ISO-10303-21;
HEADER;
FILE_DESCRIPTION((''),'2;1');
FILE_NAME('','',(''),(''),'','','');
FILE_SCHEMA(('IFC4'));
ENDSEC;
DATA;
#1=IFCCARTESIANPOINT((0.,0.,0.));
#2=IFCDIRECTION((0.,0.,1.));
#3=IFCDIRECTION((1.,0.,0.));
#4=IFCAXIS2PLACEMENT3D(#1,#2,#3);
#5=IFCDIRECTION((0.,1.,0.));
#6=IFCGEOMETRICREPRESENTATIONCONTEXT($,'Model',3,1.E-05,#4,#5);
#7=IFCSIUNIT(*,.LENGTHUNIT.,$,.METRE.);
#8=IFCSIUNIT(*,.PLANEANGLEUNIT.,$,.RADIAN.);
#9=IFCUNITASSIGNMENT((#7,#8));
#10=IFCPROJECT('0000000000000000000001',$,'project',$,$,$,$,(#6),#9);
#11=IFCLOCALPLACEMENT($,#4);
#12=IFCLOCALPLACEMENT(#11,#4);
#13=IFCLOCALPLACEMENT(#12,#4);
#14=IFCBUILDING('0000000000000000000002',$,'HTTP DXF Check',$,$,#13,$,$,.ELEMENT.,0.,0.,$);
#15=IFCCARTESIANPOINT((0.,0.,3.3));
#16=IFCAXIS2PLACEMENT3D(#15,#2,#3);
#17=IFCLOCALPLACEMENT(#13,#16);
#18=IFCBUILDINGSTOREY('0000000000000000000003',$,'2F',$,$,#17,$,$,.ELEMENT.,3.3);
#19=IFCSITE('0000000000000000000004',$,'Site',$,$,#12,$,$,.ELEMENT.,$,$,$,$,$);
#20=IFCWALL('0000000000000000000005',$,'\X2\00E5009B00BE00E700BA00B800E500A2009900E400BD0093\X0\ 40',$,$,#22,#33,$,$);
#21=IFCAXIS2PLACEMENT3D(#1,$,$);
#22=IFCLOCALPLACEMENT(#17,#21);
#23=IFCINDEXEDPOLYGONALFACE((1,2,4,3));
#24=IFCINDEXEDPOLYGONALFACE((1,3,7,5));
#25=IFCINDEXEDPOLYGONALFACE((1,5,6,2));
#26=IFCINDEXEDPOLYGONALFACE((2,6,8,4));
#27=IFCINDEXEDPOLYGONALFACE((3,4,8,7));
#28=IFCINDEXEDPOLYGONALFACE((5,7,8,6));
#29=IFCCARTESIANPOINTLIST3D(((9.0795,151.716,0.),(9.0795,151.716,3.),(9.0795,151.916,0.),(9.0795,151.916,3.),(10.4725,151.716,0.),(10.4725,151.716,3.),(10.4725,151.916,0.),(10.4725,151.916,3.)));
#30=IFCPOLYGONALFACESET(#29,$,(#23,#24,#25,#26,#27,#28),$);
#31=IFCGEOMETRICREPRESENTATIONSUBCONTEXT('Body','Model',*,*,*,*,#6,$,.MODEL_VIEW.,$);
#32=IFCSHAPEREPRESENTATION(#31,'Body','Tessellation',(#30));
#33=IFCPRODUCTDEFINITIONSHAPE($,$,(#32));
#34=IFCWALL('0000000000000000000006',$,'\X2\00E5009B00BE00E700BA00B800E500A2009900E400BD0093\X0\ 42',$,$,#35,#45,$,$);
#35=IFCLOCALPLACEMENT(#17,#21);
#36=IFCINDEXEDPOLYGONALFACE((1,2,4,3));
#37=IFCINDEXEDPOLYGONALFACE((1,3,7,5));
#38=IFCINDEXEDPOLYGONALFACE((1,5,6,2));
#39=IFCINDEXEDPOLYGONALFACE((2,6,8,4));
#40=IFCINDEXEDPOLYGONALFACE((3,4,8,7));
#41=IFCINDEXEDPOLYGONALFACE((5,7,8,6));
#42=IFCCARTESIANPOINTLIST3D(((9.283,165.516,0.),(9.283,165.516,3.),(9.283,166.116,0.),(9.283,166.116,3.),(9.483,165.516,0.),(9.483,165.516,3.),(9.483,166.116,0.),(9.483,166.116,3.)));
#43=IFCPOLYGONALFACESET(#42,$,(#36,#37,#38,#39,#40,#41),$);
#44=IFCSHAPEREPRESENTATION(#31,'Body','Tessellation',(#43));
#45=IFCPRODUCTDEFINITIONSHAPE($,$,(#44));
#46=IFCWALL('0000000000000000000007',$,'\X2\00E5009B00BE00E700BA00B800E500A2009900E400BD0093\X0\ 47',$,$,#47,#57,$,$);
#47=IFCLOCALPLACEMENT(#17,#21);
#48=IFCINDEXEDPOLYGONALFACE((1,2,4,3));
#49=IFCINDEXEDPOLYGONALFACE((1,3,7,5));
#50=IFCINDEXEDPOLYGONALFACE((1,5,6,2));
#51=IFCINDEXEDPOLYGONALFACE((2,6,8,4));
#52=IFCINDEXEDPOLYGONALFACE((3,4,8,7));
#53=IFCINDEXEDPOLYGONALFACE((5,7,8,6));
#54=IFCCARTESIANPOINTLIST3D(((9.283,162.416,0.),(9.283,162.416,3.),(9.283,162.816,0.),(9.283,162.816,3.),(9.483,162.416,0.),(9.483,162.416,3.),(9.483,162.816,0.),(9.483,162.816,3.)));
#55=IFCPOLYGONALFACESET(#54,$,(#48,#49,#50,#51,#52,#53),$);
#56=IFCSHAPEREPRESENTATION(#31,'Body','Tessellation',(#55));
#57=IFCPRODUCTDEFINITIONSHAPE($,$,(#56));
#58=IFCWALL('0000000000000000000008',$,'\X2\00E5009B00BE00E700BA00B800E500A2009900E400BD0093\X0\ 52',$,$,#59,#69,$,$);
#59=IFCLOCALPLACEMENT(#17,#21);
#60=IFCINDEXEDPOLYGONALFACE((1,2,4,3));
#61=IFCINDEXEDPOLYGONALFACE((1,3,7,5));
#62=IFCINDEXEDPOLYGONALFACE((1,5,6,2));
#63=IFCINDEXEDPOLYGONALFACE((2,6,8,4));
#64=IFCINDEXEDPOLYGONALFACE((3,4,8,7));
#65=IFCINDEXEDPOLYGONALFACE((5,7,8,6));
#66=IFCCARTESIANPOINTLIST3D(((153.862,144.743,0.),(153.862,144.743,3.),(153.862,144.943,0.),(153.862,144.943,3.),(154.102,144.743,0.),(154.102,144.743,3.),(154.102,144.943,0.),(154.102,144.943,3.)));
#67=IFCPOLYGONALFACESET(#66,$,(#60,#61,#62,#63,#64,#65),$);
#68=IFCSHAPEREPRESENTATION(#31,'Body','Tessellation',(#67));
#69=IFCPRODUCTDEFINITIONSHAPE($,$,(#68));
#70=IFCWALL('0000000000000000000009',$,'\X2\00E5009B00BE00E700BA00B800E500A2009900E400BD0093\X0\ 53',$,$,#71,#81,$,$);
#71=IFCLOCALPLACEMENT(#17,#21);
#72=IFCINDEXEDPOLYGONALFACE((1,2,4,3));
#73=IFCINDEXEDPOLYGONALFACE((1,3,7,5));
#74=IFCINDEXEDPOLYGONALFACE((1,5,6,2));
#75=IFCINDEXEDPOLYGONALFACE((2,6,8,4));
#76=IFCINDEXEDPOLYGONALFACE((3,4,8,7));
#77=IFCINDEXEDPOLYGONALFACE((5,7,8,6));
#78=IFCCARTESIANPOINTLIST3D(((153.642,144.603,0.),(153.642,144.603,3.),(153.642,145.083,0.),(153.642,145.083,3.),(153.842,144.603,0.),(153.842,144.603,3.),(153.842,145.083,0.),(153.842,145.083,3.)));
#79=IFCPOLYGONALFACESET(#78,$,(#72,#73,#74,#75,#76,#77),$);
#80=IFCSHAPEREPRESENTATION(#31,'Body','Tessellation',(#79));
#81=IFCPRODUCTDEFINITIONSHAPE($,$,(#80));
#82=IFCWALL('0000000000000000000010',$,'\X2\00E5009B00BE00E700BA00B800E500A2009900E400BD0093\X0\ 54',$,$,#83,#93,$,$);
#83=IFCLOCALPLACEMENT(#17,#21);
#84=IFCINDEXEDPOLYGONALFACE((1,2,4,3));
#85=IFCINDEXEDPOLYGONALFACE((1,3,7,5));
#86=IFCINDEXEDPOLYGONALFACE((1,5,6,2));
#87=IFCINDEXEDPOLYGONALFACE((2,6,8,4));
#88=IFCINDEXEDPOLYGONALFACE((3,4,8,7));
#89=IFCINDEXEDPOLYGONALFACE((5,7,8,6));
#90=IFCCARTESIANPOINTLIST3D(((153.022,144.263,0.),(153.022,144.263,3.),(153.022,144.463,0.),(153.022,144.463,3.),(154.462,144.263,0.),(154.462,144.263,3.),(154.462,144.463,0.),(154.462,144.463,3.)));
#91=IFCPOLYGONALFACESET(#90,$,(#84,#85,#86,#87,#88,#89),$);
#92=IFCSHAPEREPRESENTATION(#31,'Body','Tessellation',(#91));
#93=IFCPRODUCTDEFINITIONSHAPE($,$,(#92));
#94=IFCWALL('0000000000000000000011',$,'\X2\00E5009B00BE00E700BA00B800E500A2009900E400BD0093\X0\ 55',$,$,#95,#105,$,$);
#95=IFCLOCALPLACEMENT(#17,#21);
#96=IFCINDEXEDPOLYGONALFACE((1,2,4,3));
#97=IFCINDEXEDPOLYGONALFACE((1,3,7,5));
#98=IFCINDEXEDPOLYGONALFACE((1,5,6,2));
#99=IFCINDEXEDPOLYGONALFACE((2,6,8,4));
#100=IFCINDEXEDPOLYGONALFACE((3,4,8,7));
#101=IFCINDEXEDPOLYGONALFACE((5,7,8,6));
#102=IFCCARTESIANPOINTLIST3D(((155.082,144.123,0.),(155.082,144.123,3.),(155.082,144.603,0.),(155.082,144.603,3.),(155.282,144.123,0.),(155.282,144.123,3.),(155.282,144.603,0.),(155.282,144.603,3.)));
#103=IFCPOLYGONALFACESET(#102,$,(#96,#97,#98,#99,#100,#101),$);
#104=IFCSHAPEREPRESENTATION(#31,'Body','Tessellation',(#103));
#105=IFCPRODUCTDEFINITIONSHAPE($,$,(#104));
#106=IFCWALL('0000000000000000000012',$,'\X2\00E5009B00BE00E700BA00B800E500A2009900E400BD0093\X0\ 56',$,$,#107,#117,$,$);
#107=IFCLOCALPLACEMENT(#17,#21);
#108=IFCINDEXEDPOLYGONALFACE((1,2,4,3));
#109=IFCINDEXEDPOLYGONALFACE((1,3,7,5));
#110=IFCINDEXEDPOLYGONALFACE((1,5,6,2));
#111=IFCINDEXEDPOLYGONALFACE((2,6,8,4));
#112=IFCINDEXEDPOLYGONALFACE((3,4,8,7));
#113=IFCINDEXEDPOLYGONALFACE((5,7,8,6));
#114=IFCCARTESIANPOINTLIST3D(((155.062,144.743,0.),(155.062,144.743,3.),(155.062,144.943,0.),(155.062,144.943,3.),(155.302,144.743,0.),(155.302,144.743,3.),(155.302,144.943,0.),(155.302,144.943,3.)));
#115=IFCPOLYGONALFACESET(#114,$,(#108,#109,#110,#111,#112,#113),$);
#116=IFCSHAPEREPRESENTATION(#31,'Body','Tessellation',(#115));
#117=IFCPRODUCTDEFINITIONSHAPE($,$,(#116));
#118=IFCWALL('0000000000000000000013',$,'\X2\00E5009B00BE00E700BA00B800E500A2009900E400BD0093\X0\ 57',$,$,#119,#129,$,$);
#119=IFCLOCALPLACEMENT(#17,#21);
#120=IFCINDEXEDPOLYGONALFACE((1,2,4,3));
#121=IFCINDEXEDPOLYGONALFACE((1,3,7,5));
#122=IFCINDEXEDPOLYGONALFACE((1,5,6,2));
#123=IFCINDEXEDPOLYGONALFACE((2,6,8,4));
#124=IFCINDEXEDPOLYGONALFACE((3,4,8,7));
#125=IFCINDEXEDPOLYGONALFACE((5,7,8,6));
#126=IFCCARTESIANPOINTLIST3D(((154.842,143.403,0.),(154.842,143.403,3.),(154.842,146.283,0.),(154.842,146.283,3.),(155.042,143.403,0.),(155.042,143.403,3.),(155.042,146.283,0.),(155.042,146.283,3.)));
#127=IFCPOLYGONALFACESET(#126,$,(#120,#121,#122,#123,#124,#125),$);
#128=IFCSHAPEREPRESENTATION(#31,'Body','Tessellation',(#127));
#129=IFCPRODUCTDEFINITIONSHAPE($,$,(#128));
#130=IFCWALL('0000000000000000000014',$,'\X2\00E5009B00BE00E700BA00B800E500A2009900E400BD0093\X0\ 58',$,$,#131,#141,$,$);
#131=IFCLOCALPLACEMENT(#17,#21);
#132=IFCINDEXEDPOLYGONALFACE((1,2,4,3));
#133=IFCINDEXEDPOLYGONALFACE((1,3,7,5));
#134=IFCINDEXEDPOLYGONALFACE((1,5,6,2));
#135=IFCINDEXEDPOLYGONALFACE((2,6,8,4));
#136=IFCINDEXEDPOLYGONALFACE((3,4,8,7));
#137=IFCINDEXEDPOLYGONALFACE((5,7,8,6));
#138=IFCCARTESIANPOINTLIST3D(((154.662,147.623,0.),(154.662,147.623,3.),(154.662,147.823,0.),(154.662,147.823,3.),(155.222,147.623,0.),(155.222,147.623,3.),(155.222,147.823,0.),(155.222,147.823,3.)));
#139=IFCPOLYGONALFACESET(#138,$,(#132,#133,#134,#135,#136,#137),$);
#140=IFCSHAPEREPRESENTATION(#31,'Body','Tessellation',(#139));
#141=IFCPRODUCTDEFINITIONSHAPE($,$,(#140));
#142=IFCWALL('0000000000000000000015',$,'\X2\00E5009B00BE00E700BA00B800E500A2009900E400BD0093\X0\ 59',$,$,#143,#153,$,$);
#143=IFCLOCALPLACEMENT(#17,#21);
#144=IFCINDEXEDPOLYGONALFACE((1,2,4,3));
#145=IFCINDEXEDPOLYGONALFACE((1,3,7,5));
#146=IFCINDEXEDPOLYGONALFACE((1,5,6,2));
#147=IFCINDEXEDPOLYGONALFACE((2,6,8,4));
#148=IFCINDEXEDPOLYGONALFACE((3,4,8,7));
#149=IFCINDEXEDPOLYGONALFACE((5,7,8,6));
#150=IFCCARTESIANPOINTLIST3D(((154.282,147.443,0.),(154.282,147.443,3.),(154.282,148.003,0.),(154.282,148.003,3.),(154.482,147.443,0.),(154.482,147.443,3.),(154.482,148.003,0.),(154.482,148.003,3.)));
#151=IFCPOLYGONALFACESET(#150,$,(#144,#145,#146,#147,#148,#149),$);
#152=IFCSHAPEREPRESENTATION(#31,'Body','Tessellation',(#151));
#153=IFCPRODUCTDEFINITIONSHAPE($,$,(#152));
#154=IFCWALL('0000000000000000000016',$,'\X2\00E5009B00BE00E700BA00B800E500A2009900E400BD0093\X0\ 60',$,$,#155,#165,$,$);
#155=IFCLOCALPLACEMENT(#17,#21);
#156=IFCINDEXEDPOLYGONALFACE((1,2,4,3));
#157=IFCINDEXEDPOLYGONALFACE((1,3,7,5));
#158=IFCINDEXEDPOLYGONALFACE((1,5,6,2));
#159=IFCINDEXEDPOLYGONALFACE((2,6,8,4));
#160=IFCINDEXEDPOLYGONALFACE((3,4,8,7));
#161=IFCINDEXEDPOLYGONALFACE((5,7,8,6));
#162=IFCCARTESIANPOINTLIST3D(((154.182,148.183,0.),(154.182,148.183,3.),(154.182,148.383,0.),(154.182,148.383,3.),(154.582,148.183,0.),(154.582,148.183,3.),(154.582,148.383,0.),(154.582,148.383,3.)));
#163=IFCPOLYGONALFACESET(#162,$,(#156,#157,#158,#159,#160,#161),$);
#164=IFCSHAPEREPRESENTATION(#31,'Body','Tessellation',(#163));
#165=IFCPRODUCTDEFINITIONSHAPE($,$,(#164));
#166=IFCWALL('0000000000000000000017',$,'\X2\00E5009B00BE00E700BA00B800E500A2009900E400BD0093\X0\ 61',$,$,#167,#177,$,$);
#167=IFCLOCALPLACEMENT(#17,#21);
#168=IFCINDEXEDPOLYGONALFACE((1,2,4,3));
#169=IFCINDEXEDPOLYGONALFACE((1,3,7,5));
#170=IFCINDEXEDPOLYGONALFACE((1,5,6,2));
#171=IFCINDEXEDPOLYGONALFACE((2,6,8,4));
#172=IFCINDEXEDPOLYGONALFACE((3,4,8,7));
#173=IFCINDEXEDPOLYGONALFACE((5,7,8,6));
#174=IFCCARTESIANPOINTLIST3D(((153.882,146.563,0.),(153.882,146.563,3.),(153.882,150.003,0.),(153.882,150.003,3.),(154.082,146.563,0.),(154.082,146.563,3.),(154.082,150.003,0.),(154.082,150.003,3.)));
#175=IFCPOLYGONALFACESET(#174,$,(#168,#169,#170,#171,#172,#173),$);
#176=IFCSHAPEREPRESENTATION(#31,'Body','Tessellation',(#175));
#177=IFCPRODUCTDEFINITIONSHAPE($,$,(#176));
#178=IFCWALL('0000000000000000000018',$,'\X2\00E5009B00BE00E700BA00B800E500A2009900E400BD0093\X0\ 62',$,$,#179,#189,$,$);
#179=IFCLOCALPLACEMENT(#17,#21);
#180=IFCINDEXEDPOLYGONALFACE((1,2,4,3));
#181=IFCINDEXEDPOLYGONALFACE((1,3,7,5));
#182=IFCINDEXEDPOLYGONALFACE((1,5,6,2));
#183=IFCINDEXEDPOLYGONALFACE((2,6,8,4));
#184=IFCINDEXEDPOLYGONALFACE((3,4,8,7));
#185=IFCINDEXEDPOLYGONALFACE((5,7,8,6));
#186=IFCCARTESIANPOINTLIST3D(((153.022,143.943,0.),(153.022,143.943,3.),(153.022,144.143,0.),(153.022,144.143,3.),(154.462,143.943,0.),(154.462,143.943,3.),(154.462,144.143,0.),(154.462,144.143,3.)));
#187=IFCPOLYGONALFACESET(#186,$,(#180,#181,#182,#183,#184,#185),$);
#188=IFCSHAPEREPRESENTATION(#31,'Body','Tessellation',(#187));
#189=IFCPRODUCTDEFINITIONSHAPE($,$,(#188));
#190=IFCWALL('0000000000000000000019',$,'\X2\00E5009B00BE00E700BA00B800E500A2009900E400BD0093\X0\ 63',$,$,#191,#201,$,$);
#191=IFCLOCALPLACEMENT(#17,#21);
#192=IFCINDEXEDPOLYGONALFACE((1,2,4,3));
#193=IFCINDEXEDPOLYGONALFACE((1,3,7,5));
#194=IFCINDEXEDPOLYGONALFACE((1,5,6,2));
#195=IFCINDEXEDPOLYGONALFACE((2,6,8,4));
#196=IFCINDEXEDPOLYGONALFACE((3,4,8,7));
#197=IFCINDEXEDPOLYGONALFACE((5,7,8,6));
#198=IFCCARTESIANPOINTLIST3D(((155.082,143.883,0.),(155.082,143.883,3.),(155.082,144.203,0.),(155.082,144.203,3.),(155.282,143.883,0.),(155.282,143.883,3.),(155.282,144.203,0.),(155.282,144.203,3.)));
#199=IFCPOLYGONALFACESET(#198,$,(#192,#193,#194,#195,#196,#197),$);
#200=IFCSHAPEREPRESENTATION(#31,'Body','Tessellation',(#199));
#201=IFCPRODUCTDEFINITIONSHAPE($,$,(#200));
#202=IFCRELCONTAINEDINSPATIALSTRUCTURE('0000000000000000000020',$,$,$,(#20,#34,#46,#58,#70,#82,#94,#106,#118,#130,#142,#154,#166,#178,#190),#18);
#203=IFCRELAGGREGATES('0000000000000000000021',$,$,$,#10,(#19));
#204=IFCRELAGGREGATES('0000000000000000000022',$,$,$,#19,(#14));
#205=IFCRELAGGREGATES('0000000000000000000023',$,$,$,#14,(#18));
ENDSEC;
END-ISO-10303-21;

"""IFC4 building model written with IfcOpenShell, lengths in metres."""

from ifc_helpers import new_model, si_unit, direction, frame, frame_2d, origin_with_axes, place, context, subcontext, project, spatial, rectangle, extrude, element, save


model = new_model("IFC4")

# Units and contexts
model_context = context("Model", 3, precision=1e-05, world=origin_with_axes(), true_north=direction((0.0, 1.0, 0.0)))
body_context = subcontext(model_context, "Body", "Model", "MODEL_VIEW")
ifc_project = project(units=[si_unit("LENGTHUNIT", "METRE"), si_unit("PLANEANGLEUNIT", "RADIAN")], contexts=[model_context])

# Site, building, storey
placement = place(None, origin_with_axes())
site_placement = place(placement, origin_with_axes())
site = spatial("IfcSite", under=ifc_project, at=site_placement, Name="Site", CompositionType="ELEMENT")
building_placement = place(site_placement, origin_with_axes())
building = spatial("IfcBuilding", under=site, at=building_placement, Name="HTTP DXF Check", CompositionType="ELEMENT", ElevationOfRefHeight=0.0, ElevationOfTerrain=0.0)
storey_placement = place(building_placement, frame((0.0, 0.0, 3.3), z_axis=(0.0, 0.0, 1.0), x_axis=(1.0, 0.0, 0.0)))
storey = spatial("IfcBuildingStorey", under=building, at=storey_placement, Name="2F", CompositionType="ELEMENT", Elevation=3.3)

# Walls
wall_1_placement = place(storey_placement, frame((9.776, 151.816, 0.0), z_axis=(0.0, 0.0, 1.0), x_axis=(-1.0, 0.0, 0.0)))
element("IfcWall", 1, at=wall_1_placement, inside=storey, Name="å\u009b¾çº¸å¢\u0099ä½\u0093 40", context=body_context, shape_type="SweptSolid", body=[
    extrude(rectangle(XDim=1.393, YDim=0.2, at=frame_2d((0.0, 0.0), x_axis=(1.0, 0.0, 0.0))), frame((0.0, 0.0, 0.0), z_axis=(0.0, 0.0, 1.0)), (0.0, 0.0, 1.0), 3.0),
])
wall_2_placement = place(storey_placement, frame((9.383, 165.816, 0.0), z_axis=(0.0, 0.0, 1.0), x_axis=(0.0, 1.0, 0.0)))
element("IfcWall", 2, at=wall_2_placement, inside=storey, Name="å\u009b¾çº¸å¢\u0099ä½\u0093 42", context=body_context, shape_type="SweptSolid", body=[
    extrude(rectangle(XDim=0.6, YDim=0.2, at=frame_2d((0.0, 0.0), x_axis=(1.0, 0.0, 0.0))), frame((0.0, 0.0, 0.0), z_axis=(0.0, 0.0, 1.0)), (0.0, 0.0, 1.0), 3.0),
])
wall_3_placement = place(storey_placement, frame((9.383, 162.616, 0.0), z_axis=(0.0, 0.0, 1.0), x_axis=(0.0, -1.0, 0.0)))
element("IfcWall", 3, at=wall_3_placement, inside=storey, Name="å\u009b¾çº¸å¢\u0099ä½\u0093 47", context=body_context, shape_type="SweptSolid", body=[
    extrude(rectangle(XDim=0.4, YDim=0.2, at=frame_2d((0.0, 0.0), x_axis=(1.0, 0.0, 0.0))), frame((0.0, 0.0, 0.0), z_axis=(0.0, 0.0, 1.0)), (0.0, 0.0, 1.0), 3.0),
])
wall_4_placement = place(storey_placement, frame((153.982, 144.843, 0.0), z_axis=(0.0, 0.0, 1.0), x_axis=(-1.0, 0.0, 0.0)))
element("IfcWall", 4, at=wall_4_placement, inside=storey, Name="å\u009b¾çº¸å¢\u0099ä½\u0093 52", context=body_context, shape_type="SweptSolid", body=[
    extrude(rectangle(XDim=0.24, YDim=0.2, at=frame_2d((0.0, 0.0), x_axis=(1.0, 0.0, 0.0))), frame((0.0, 0.0, 0.0), z_axis=(0.0, 0.0, 1.0)), (0.0, 0.0, 1.0), 3.0),
])
wall_5_placement = place(storey_placement, frame((153.742, 144.843, 0.0), z_axis=(0.0, 0.0, 1.0), x_axis=(0.0, -1.0, 0.0)))
element("IfcWall", 5, at=wall_5_placement, inside=storey, Name="å\u009b¾çº¸å¢\u0099ä½\u0093 53", context=body_context, shape_type="SweptSolid", body=[
    extrude(rectangle(XDim=0.48, YDim=0.2, at=frame_2d((0.0, 0.0), x_axis=(1.0, 0.0, 0.0))), frame((0.0, 0.0, 0.0), z_axis=(0.0, 0.0, 1.0)), (0.0, 0.0, 1.0), 3.0),
])
wall_6_placement = place(storey_placement, frame((153.742, 144.363, 0.0), z_axis=(0.0, 0.0, 1.0), x_axis=(1.0, 0.0, 0.0)))
element("IfcWall", 6, at=wall_6_placement, inside=storey, Name="å\u009b¾çº¸å¢\u0099ä½\u0093 54", context=body_context, shape_type="SweptSolid", body=[
    extrude(rectangle(XDim=1.44, YDim=0.2, at=frame_2d((0.0, 0.0), x_axis=(1.0, 0.0, 0.0))), frame((0.0, 0.0, 0.0), z_axis=(0.0, 0.0, 1.0)), (0.0, 0.0, 1.0), 3.0),
])
wall_7_placement = place(storey_placement, frame((155.182, 144.363, 0.0), z_axis=(0.0, 0.0, 1.0), x_axis=(0.0, 1.0, 0.0)))
element("IfcWall", 7, at=wall_7_placement, inside=storey, Name="å\u009b¾çº¸å¢\u0099ä½\u0093 55", context=body_context, shape_type="SweptSolid", body=[
    extrude(rectangle(XDim=0.48, YDim=0.2, at=frame_2d((0.0, 0.0), x_axis=(1.0, 0.0, 0.0))), frame((0.0, 0.0, 0.0), z_axis=(0.0, 0.0, 1.0)), (0.0, 0.0, 1.0), 3.0),
])
wall_8_placement = place(storey_placement, frame((155.182, 144.843, 0.0), z_axis=(0.0, 0.0, 1.0), x_axis=(-1.0, 0.0, 0.0)))
element("IfcWall", 8, at=wall_8_placement, inside=storey, Name="å\u009b¾çº¸å¢\u0099ä½\u0093 56", context=body_context, shape_type="SweptSolid", body=[
    extrude(rectangle(XDim=0.24, YDim=0.2, at=frame_2d((0.0, 0.0), x_axis=(1.0, 0.0, 0.0))), frame((0.0, 0.0, 0.0), z_axis=(0.0, 0.0, 1.0)), (0.0, 0.0, 1.0), 3.0),
])
wall_9_placement = place(storey_placement, frame((154.942, 144.843, 0.0), z_axis=(0.0, 0.0, 1.0), x_axis=(0.0, 1.0, 0.0)))
element("IfcWall", 9, at=wall_9_placement, inside=storey, Name="å\u009b¾çº¸å¢\u0099ä½\u0093 57", context=body_context, shape_type="SweptSolid", body=[
    extrude(rectangle(XDim=2.88, YDim=0.2, at=frame_2d((0.0, 0.0), x_axis=(1.0, 0.0, 0.0))), frame((0.0, 0.0, 0.0), z_axis=(0.0, 0.0, 1.0)), (0.0, 0.0, 1.0), 3.0),
])
for number, where, z_axis, x_axis, name in (
    (10, (154.942, 147.723, 0.0), (0.0, 0.0, 1.0), (-1.0, 0.0, 0.0), "å\u009b¾çº¸å¢\u0099ä½\u0093 58"),
    (11, (154.382, 147.723, 0.0), (0.0, 0.0, 1.0), (0.0, 1.0, 0.0), "å\u009b¾çº¸å¢\u0099ä½\u0093 59"),
):
    element("IfcWall", number, at=place(storey_placement, frame(where, z_axis=z_axis, x_axis=x_axis)), inside=storey, Name=name, context=body_context, shape_type="SweptSolid", body=[
        extrude(rectangle(XDim=0.56, YDim=0.2, at=frame_2d((0.0, 0.0), x_axis=(1.0, 0.0, 0.0))), frame((0.0, 0.0, 0.0), z_axis=(0.0, 0.0, 1.0)), (0.0, 0.0, 1.0), 3.0),
    ])
wall_10_placement = place(storey_placement, frame((154.382, 148.283, 0.0), z_axis=(0.0, 0.0, 1.0), x_axis=(-1.0, 0.0, 0.0)))
element("IfcWall", 12, at=wall_10_placement, inside=storey, Name="å\u009b¾çº¸å¢\u0099ä½\u0093 60", context=body_context, shape_type="SweptSolid", body=[
    extrude(rectangle(XDim=0.4, YDim=0.2, at=frame_2d((0.0, 0.0), x_axis=(1.0, 0.0, 0.0))), frame((0.0, 0.0, 0.0), z_axis=(0.0, 0.0, 1.0)), (0.0, 0.0, 1.0), 3.0),
])
wall_11_placement = place(storey_placement, frame((153.982, 148.283, 0.0), z_axis=(0.0, 0.0, 1.0), x_axis=(0.0, -1.0, 0.0)))
element("IfcWall", 13, at=wall_11_placement, inside=storey, Name="å\u009b¾çº¸å¢\u0099ä½\u0093 61", context=body_context, shape_type="SweptSolid", body=[
    extrude(rectangle(XDim=3.44, YDim=0.2, at=frame_2d((0.0, 0.0), x_axis=(1.0, 0.0, 0.0))), frame((0.0, 0.0, 0.0), z_axis=(0.0, 0.0, 1.0)), (0.0, 0.0, 1.0), 3.0),
])
wall_12_placement = place(storey_placement, frame((153.742, 144.043, 0.0), z_axis=(0.0, 0.0, 1.0), x_axis=(1.0, 0.0, 0.0)))
element("IfcWall", 14, at=wall_12_placement, inside=storey, Name="å\u009b¾çº¸å¢\u0099ä½\u0093 62", context=body_context, shape_type="SweptSolid", body=[
    extrude(rectangle(XDim=1.44, YDim=0.2, at=frame_2d((0.0, 0.0), x_axis=(1.0, 0.0, 0.0))), frame((0.0, 0.0, 0.0), z_axis=(0.0, 0.0, 1.0)), (0.0, 0.0, 1.0), 3.0),
])
wall_13_placement = place(storey_placement, frame((155.182, 144.043, 0.0), z_axis=(0.0, 0.0, 1.0), x_axis=(0.0, 1.0, 0.0)))
element("IfcWall", 15, at=wall_13_placement, inside=storey, Name="å\u009b¾çº¸å¢\u0099ä½\u0093 63", context=body_context, shape_type="SweptSolid", body=[
    extrude(rectangle(XDim=0.32, YDim=0.2, at=frame_2d((0.0, 0.0), x_axis=(1.0, 0.0, 0.0))), frame((0.0, 0.0, 0.0), z_axis=(0.0, 0.0, 1.0)), (0.0, 0.0, 1.0), 3.0),
])

save(model, "model.ifc")
